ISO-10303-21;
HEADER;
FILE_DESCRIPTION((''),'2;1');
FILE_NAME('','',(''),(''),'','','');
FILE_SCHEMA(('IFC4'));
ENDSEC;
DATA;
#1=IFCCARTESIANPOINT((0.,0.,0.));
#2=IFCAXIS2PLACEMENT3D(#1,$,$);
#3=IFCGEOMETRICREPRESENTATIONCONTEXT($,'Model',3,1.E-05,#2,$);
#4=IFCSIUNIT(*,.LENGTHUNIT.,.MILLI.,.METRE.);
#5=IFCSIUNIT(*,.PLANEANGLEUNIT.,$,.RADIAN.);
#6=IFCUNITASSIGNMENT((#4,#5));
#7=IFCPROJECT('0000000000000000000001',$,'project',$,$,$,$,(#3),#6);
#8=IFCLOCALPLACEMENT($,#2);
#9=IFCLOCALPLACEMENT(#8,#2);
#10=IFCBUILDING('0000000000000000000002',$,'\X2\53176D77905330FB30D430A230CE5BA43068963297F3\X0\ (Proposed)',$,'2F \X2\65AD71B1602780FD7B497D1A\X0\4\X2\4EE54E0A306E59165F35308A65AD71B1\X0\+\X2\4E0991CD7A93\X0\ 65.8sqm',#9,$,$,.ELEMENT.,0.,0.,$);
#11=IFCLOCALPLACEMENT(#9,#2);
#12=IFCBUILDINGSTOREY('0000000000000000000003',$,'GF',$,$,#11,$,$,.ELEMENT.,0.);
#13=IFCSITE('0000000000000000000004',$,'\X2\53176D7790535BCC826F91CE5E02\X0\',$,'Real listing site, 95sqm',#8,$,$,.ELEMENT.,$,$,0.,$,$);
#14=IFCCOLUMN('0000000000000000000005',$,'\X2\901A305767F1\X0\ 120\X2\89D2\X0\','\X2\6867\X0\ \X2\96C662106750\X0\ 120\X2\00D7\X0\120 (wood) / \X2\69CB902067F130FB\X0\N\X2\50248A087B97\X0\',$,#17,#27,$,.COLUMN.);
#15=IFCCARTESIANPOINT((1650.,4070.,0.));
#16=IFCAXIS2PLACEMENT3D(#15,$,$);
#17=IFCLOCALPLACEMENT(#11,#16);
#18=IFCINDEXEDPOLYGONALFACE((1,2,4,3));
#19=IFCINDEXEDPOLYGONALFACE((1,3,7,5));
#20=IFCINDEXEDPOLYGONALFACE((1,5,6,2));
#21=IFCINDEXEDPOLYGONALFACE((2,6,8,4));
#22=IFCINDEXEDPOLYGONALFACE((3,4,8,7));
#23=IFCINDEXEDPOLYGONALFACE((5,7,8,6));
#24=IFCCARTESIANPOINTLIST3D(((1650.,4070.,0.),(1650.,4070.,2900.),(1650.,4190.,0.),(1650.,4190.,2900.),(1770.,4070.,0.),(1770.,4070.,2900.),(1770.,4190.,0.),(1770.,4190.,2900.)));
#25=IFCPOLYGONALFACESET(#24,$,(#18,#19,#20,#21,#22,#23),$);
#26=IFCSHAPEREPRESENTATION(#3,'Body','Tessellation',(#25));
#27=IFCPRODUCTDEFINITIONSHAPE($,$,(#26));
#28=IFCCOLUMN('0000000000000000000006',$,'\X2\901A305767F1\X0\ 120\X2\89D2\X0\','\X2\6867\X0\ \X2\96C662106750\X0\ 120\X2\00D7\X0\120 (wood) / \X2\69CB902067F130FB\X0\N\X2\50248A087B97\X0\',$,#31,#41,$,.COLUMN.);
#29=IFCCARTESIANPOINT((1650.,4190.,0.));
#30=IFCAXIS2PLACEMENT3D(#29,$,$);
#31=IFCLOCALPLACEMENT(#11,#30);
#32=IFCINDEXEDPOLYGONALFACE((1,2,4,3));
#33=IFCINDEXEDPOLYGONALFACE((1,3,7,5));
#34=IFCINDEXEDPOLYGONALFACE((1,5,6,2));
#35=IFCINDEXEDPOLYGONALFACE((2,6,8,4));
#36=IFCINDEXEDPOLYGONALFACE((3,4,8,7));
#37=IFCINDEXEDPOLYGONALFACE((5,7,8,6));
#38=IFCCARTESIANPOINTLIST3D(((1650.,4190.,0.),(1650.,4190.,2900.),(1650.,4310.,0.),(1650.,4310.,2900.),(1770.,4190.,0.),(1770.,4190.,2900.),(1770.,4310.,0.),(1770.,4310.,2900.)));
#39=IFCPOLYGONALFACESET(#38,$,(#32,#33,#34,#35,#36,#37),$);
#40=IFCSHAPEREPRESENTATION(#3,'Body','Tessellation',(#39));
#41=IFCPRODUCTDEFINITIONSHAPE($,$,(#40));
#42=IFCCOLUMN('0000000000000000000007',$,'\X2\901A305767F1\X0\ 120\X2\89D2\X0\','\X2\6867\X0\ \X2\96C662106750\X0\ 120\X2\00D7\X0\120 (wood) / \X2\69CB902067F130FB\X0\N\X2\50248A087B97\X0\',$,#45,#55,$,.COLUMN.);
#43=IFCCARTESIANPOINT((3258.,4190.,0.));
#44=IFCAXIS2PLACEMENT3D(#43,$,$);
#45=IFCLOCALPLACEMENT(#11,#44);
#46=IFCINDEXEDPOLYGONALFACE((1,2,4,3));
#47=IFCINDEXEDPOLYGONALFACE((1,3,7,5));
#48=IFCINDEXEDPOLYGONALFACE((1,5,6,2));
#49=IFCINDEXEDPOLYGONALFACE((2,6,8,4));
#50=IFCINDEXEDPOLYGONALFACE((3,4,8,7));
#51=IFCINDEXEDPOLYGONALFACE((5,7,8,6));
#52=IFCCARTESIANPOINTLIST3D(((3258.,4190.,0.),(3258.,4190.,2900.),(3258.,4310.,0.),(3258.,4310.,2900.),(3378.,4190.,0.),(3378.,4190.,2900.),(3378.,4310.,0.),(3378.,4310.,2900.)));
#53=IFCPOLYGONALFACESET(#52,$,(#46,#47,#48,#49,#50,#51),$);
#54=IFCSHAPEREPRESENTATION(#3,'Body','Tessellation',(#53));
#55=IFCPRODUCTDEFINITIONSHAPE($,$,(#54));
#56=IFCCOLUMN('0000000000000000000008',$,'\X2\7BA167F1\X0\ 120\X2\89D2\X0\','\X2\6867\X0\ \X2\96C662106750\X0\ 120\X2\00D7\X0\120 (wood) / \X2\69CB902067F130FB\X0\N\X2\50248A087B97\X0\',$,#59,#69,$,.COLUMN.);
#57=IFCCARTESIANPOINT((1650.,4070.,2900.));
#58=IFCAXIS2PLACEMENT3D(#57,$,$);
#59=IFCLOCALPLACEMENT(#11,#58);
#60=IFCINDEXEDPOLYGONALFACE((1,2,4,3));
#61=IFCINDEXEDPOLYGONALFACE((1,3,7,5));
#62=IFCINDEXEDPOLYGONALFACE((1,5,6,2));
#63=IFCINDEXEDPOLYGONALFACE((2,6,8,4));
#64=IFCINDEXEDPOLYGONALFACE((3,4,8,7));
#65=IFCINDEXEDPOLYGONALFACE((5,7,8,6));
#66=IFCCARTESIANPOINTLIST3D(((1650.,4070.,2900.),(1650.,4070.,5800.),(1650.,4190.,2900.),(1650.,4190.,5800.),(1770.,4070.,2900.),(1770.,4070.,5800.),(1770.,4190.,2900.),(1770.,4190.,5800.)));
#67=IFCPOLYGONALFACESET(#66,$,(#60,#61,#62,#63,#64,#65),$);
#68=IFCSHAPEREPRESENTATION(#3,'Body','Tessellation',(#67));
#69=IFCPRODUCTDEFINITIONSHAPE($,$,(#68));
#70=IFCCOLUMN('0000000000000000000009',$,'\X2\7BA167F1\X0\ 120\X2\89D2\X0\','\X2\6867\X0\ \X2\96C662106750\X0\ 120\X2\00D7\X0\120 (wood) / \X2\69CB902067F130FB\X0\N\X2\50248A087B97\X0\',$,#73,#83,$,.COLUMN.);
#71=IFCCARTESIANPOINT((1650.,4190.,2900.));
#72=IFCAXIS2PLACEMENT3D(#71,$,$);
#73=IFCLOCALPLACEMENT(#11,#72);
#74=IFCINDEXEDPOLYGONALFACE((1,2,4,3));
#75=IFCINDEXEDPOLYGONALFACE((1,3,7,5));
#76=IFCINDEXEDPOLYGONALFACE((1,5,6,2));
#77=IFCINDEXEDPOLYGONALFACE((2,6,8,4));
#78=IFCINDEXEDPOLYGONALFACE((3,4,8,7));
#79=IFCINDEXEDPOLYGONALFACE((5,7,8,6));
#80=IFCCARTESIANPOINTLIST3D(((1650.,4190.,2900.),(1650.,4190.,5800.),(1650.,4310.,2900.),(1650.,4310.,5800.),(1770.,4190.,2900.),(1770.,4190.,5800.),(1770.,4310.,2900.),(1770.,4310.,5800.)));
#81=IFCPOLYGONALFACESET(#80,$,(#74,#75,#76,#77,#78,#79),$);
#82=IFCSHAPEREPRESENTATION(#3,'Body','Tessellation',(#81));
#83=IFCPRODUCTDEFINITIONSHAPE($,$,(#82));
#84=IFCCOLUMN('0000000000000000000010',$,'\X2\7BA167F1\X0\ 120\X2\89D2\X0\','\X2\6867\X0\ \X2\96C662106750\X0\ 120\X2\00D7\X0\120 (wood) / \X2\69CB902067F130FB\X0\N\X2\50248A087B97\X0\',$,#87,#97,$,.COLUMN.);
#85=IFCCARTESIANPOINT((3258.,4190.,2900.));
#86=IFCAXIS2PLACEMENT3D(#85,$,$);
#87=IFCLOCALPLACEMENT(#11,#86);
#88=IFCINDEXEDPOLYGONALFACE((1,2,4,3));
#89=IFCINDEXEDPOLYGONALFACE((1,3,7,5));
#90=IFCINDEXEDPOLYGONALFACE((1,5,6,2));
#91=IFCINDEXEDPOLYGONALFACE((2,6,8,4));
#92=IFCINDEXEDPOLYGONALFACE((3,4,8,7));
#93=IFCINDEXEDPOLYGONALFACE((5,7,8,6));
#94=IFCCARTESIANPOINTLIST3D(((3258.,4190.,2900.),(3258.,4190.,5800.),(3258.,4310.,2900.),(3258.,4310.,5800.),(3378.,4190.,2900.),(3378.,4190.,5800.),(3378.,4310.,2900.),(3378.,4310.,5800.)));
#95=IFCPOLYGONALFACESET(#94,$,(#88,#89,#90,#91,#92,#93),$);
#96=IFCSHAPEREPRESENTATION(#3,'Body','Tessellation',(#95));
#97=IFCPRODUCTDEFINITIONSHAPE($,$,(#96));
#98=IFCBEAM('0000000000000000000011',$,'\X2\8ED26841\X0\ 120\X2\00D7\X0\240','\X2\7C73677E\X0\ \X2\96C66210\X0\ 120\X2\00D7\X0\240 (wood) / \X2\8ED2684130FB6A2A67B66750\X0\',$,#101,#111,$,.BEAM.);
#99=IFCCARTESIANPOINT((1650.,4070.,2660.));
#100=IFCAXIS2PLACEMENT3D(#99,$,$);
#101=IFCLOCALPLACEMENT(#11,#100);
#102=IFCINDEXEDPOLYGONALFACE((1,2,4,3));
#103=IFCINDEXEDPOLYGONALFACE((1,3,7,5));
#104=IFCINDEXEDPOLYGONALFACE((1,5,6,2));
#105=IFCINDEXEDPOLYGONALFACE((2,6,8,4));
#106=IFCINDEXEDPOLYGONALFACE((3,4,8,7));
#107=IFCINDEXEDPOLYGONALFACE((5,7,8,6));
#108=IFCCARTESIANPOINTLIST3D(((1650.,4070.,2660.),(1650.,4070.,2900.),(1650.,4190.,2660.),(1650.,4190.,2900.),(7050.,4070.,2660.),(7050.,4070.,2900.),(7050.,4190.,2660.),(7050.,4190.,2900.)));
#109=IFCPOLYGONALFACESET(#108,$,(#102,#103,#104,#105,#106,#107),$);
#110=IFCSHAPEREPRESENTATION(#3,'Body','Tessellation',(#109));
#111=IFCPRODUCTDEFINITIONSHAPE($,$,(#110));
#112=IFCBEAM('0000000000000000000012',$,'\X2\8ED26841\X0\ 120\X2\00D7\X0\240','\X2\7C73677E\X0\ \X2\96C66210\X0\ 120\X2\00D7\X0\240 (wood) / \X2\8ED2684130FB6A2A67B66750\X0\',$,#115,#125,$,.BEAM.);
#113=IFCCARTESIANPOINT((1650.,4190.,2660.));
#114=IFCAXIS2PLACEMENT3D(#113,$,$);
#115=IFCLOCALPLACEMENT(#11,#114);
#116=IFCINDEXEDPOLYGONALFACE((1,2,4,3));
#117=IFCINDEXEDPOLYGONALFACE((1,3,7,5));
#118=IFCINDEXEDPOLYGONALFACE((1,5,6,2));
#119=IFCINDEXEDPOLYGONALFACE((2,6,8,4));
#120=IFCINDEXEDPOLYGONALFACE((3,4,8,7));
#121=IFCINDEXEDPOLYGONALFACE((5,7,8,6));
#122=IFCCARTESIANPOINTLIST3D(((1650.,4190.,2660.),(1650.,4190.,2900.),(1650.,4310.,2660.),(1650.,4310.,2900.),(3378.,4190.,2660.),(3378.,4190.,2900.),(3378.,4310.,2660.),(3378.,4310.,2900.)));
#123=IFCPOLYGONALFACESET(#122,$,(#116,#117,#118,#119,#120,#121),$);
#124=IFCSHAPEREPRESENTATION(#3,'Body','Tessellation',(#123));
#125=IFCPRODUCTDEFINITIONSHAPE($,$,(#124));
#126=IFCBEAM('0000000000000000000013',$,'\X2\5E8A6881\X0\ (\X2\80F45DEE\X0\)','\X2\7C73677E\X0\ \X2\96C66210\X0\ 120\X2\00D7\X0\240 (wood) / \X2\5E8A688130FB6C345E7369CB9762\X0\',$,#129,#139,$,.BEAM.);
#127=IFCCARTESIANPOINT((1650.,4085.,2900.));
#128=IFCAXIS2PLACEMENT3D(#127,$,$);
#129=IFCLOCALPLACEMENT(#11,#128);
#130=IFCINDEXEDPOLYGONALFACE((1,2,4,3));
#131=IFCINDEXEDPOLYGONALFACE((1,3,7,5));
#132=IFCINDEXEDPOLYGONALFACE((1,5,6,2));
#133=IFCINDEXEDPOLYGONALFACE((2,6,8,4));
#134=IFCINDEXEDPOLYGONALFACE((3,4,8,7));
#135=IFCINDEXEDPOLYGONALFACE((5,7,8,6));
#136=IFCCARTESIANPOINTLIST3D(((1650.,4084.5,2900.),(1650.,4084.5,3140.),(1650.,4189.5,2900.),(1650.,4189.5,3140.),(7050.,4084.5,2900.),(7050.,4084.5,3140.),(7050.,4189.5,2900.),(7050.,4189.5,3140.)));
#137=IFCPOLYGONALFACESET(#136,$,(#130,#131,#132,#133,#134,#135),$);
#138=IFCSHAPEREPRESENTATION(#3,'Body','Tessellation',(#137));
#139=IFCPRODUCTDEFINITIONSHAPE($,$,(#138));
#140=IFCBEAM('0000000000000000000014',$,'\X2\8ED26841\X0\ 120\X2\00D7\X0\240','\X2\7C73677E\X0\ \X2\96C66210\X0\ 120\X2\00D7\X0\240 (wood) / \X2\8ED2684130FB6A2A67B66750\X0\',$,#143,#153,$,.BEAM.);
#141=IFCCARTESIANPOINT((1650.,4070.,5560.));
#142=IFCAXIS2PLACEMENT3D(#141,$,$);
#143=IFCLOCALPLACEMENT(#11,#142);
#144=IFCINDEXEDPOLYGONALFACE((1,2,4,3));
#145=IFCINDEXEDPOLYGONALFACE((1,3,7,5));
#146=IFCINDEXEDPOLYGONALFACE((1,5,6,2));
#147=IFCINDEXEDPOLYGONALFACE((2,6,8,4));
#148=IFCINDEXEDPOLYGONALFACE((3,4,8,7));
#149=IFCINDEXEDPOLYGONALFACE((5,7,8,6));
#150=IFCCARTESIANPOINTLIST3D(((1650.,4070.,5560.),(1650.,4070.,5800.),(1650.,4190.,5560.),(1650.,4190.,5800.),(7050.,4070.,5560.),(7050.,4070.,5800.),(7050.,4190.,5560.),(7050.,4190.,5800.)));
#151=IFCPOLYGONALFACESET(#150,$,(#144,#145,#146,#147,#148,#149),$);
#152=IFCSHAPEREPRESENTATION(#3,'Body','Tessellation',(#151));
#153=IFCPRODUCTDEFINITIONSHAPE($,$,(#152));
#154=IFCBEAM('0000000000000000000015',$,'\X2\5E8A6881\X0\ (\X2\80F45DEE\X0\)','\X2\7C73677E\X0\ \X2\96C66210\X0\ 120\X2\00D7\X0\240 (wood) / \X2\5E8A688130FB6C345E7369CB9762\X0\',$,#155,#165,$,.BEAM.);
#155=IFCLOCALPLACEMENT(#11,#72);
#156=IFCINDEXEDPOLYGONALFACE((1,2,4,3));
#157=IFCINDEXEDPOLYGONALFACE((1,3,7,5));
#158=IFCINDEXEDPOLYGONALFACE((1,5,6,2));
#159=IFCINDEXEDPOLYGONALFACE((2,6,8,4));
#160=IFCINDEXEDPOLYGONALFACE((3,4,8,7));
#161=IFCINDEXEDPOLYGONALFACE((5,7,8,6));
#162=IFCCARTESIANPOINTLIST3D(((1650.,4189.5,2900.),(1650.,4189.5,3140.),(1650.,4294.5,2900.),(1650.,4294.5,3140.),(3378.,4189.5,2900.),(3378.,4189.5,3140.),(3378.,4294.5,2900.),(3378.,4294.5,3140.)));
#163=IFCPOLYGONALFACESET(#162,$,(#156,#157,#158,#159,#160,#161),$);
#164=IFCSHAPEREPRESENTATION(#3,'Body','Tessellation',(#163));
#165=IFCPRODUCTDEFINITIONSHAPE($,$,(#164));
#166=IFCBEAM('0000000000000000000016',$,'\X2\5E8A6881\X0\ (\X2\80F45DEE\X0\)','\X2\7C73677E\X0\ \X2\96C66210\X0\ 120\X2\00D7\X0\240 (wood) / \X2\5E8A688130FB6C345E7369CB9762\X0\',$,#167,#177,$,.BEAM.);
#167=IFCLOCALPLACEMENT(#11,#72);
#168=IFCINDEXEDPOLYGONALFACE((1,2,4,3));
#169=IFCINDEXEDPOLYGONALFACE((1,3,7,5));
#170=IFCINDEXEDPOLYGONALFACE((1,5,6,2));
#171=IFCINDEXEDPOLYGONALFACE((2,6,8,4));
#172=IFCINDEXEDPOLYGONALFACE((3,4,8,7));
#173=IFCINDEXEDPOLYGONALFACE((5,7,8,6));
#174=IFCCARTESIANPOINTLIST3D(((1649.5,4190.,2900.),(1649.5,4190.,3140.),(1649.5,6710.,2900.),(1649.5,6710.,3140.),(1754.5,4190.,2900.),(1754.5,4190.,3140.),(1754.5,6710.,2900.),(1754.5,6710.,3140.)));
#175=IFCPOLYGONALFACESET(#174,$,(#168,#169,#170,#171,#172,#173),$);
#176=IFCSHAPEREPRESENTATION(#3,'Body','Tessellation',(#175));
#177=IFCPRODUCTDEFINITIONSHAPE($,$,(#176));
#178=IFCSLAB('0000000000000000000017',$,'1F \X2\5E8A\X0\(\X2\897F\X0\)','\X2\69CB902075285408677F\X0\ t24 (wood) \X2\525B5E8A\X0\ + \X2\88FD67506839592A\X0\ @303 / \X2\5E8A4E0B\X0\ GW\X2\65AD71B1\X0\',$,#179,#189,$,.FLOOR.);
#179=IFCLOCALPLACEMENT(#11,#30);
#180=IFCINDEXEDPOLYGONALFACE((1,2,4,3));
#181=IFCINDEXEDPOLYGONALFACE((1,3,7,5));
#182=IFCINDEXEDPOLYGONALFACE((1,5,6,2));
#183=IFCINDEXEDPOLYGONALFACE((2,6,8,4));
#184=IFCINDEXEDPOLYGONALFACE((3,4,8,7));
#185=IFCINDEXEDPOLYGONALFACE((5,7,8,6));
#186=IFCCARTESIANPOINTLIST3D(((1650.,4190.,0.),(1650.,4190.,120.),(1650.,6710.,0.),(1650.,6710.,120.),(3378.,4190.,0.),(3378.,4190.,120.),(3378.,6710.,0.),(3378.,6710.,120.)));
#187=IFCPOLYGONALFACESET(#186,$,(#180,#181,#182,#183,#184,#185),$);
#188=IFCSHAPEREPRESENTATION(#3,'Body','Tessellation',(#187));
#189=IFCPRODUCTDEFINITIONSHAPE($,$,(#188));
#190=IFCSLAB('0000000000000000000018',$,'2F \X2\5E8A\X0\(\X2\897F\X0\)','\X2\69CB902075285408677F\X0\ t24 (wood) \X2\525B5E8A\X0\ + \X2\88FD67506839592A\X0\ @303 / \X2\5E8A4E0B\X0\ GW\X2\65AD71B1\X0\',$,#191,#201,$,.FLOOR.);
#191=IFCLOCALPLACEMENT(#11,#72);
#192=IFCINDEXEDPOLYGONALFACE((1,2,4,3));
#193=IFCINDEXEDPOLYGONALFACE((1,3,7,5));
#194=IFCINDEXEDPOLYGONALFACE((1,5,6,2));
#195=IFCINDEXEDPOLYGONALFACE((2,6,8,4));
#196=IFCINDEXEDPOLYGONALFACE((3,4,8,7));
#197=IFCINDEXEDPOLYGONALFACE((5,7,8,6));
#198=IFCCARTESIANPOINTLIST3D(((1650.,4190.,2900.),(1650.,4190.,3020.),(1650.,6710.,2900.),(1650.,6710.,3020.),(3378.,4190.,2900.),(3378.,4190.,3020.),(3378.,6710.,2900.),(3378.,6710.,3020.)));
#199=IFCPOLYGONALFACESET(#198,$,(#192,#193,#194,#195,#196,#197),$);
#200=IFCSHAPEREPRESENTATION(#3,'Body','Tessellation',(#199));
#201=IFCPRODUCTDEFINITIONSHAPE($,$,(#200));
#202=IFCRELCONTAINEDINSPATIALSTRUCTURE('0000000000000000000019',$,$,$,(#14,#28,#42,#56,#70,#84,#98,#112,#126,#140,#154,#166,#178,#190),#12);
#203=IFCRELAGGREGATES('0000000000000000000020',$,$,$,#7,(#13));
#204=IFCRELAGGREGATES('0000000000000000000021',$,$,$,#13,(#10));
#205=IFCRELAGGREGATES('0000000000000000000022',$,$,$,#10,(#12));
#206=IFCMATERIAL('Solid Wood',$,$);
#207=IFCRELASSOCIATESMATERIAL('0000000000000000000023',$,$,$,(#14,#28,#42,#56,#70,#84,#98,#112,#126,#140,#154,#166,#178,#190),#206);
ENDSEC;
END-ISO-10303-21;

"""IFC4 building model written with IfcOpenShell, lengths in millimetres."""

from ifc_helpers import new_model, si_unit, frame, frame_2d, origin, place, context, project, spatial, rectangle, extrude, material, element, save


model = new_model("IFC4")

# Units and contexts
model_context = context("Model", 3, precision=1e-05, world=origin())
ifc_project = project(units=[si_unit("LENGTHUNIT", "METRE", prefix="MILLI"), si_unit("PLANEANGLEUNIT", "RADIAN")], contexts=[model_context])

# Site, building, storey
site_placement = place(None, origin())
site = spatial("IfcSite", under=ifc_project, at=site_placement, Name="北海道富良野市", ObjectType="Real listing site, 95sqm", CompositionType="ELEMENT", RefElevation=0.0)
building_placement = place(site_placement, origin())
building = spatial("IfcBuilding", under=site, at=building_placement, Name="北海道・ピアノ室と防音 (Proposed)", ObjectType="2F 断熱性能等級4以上の外張り断熱+三重窓 65.8sqm", CompositionType="ELEMENT", ElevationOfRefHeight=0.0, ElevationOfTerrain=0.0)
storey_placement = place(building_placement, origin())
storey = spatial("IfcBuildingStorey", under=building, at=storey_placement, Name="GF", CompositionType="ELEMENT", Elevation=0.0)

# Columns
ifc_material_1 = material(Name="Solid Wood")
column_1_placement = place(storey_placement, frame((1650.0, 4070.0, 0.0)))
element("IfcColumn", 1, at=column_1_placement, inside=storey, material=ifc_material_1, Name="通し柱 120角", Description="桧 集成材 120×120 (wood) / 構造柱・N値計算", PredefinedType="COLUMN", context=model_context, shape_type="SweptSolid", body=[
    extrude(rectangle(XDim=120.0, YDim=120.0, at=frame_2d((60.0, 60.0))), frame((1650.0, 4070.0, 0.0)), (0.0, 0.0, 1.0), 2900.0),
])
column_2_placement = place(storey_placement, frame((1650.0, 4190.0, 0.0)))
element("IfcColumn", 2, at=column_2_placement, inside=storey, material=ifc_material_1, Name="通し柱 120角", Description="桧 集成材 120×120 (wood) / 構造柱・N値計算", PredefinedType="COLUMN", context=model_context, shape_type="SweptSolid", body=[
    extrude(rectangle(XDim=120.0, YDim=120.0, at=frame_2d((60.0, 60.0))), frame((1650.0, 4190.0, 0.0)), (0.0, 0.0, 1.0), 2900.0),
])
column_3_placement = place(storey_placement, frame((3258.0, 4190.0, 0.0)))
element("IfcColumn", 3, at=column_3_placement, inside=storey, material=ifc_material_1, Name="通し柱 120角", Description="桧 集成材 120×120 (wood) / 構造柱・N値計算", PredefinedType="COLUMN", context=model_context, shape_type="SweptSolid", body=[
    extrude(rectangle(XDim=120.0, YDim=120.0, at=frame_2d((60.0, 60.0))), frame((3258.0, 4190.0, 0.0)), (0.0, 0.0, 1.0), 2900.0),
])
column_4_placement = place(storey_placement, frame((1650.0, 4070.0, 2900.0)))
element("IfcColumn", 4, at=column_4_placement, inside=storey, material=ifc_material_1, Name="管柱 120角", Description="桧 集成材 120×120 (wood) / 構造柱・N値計算", PredefinedType="COLUMN", context=model_context, shape_type="SweptSolid", body=[
    extrude(rectangle(XDim=120.0, YDim=120.0, at=frame_2d((60.0, 60.0))), frame((1650.0, 4070.0, 2900.0)), (0.0, 0.0, 1.0), 2900.0),
])
column_5_placement = place(storey_placement, frame((1650.0, 4190.0, 2900.0)))
element("IfcColumn", 5, at=column_5_placement, inside=storey, material=ifc_material_1, Name="管柱 120角", Description="桧 集成材 120×120 (wood) / 構造柱・N値計算", PredefinedType="COLUMN", context=model_context, shape_type="SweptSolid", body=[
    extrude(rectangle(XDim=120.0, YDim=120.0, at=frame_2d((60.0, 60.0))), frame((1650.0, 4190.0, 2900.0)), (0.0, 0.0, 1.0), 2900.0),
])
column_6_placement = place(storey_placement, frame((3258.0, 4190.0, 2900.0)))
element("IfcColumn", 6, at=column_6_placement, inside=storey, material=ifc_material_1, Name="管柱 120角", Description="桧 集成材 120×120 (wood) / 構造柱・N値計算", PredefinedType="COLUMN", context=model_context, shape_type="SweptSolid", body=[
    extrude(rectangle(XDim=120.0, YDim=120.0, at=frame_2d((60.0, 60.0))), frame((3258.0, 4190.0, 2900.0)), (0.0, 0.0, 1.0), 2900.0),
])

# Beams
beam_1_placement = place(storey_placement, frame((1650.0, 4070.0, 2660.0)))
element("IfcBeam", 7, at=beam_1_placement, inside=storey, material=ifc_material_1, Name="軒桁 120×240", Description="米松 集成 120×240 (wood) / 軒桁・横架材", PredefinedType="BEAM", context=model_context, shape_type="SweptSolid", body=[
    extrude(rectangle(XDim=5400.0, YDim=120.0, at=frame_2d((2700.0, 60.0))), frame((1650.0, 4070.0, 2660.0)), (0.0, 0.0, 1.0), 240.0),
])
beam_2_placement = place(storey_placement, frame((1650.0, 4190.0, 2660.0)))
element("IfcBeam", 8, at=beam_2_placement, inside=storey, material=ifc_material_1, Name="軒桁 120×240", Description="米松 集成 120×240 (wood) / 軒桁・横架材", PredefinedType="BEAM", context=model_context, shape_type="SweptSolid", body=[
    extrude(rectangle(XDim=1728.0, YDim=120.0, at=frame_2d((864.0, 60.0))), frame((1650.0, 4190.0, 2660.0)), (0.0, 0.0, 1.0), 240.0),
])
beam_3_placement = place(storey_placement, frame((1650.0, 4085.0, 2900.0)))
element("IfcBeam", 9, at=beam_3_placement, inside=storey, material=ifc_material_1, Name="床梁 (胴差)", Description="米松 集成 120×240 (wood) / 床梁・水平構面", PredefinedType="BEAM", context=model_context, shape_type="SweptSolid", body=[
    extrude(rectangle(XDim=5400.0, YDim=105.0, at=frame_2d((2700.0, 52.0))), frame((1650.0, 4085.0, 2900.0)), (0.0, 0.0, 1.0), 240.0),
])
beam_4_placement = place(storey_placement, frame((1650.0, 4070.0, 5560.0)))
element("IfcBeam", 10, at=beam_4_placement, inside=storey, material=ifc_material_1, Name="軒桁 120×240", Description="米松 集成 120×240 (wood) / 軒桁・横架材", PredefinedType="BEAM", context=model_context, shape_type="SweptSolid", body=[
    extrude(rectangle(XDim=5400.0, YDim=120.0, at=frame_2d((2700.0, 60.0))), frame((1650.0, 4070.0, 5560.0)), (0.0, 0.0, 1.0), 240.0),
])
beam_5_placement = place(storey_placement, frame((1650.0, 4190.0, 2900.0)))
element("IfcBeam", 11, at=beam_5_placement, inside=storey, material=ifc_material_1, Name="床梁 (胴差)", Description="米松 集成 120×240 (wood) / 床梁・水平構面", PredefinedType="BEAM", context=model_context, shape_type="SweptSolid", body=[
    extrude(rectangle(XDim=1728.0, YDim=105.0, at=frame_2d((864.0, 52.0))), frame((1650.0, 4190.0, 2900.0)), (0.0, 0.0, 1.0), 240.0),
])
beam_6_placement = place(storey_placement, frame((1650.0, 4190.0, 2900.0)))
element("IfcBeam", 12, at=beam_6_placement, inside=storey, material=ifc_material_1, Name="床梁 (胴差)", Description="米松 集成 120×240 (wood) / 床梁・水平構面", PredefinedType="BEAM", context=model_context, shape_type="SweptSolid", body=[
    extrude(rectangle(XDim=105.0, YDim=2520.0, at=frame_2d((52.0, 1260.0))), frame((1650.0, 4190.0, 2900.0)), (0.0, 0.0, 1.0), 240.0),
])

# Slabs
slab_1_placement = place(storey_placement, frame((1650.0, 4190.0, 0.0)))
element("IfcSlab", 13, at=slab_1_placement, inside=storey, material=ifc_material_1, Name="1F 床(西)", Description="構造用合板 t24 (wood) 剛床 + 製材根太 @303 / 床下 GW断熱", PredefinedType="FLOOR", context=model_context, shape_type="SweptSolid", body=[
    extrude(rectangle(XDim=1728.0, YDim=2520.0, at=frame_2d((864.0, 1260.0))), frame((1650.0, 4190.0, 0.0)), (0.0, 0.0, 1.0), 120.0),
])
slab_2_placement = place(storey_placement, frame((1650.0, 4190.0, 2900.0)))
element("IfcSlab", 14, at=slab_2_placement, inside=storey, material=ifc_material_1, Name="2F 床(西)", Description="構造用合板 t24 (wood) 剛床 + 製材根太 @303 / 床下 GW断熱", PredefinedType="FLOOR", context=model_context, shape_type="SweptSolid", body=[
    extrude(rectangle(XDim=1728.0, YDim=2520.0, at=frame_2d((864.0, 1260.0))), frame((1650.0, 4190.0, 2900.0)), (0.0, 0.0, 1.0), 120.0),
])

save(model, "model.ifc")
